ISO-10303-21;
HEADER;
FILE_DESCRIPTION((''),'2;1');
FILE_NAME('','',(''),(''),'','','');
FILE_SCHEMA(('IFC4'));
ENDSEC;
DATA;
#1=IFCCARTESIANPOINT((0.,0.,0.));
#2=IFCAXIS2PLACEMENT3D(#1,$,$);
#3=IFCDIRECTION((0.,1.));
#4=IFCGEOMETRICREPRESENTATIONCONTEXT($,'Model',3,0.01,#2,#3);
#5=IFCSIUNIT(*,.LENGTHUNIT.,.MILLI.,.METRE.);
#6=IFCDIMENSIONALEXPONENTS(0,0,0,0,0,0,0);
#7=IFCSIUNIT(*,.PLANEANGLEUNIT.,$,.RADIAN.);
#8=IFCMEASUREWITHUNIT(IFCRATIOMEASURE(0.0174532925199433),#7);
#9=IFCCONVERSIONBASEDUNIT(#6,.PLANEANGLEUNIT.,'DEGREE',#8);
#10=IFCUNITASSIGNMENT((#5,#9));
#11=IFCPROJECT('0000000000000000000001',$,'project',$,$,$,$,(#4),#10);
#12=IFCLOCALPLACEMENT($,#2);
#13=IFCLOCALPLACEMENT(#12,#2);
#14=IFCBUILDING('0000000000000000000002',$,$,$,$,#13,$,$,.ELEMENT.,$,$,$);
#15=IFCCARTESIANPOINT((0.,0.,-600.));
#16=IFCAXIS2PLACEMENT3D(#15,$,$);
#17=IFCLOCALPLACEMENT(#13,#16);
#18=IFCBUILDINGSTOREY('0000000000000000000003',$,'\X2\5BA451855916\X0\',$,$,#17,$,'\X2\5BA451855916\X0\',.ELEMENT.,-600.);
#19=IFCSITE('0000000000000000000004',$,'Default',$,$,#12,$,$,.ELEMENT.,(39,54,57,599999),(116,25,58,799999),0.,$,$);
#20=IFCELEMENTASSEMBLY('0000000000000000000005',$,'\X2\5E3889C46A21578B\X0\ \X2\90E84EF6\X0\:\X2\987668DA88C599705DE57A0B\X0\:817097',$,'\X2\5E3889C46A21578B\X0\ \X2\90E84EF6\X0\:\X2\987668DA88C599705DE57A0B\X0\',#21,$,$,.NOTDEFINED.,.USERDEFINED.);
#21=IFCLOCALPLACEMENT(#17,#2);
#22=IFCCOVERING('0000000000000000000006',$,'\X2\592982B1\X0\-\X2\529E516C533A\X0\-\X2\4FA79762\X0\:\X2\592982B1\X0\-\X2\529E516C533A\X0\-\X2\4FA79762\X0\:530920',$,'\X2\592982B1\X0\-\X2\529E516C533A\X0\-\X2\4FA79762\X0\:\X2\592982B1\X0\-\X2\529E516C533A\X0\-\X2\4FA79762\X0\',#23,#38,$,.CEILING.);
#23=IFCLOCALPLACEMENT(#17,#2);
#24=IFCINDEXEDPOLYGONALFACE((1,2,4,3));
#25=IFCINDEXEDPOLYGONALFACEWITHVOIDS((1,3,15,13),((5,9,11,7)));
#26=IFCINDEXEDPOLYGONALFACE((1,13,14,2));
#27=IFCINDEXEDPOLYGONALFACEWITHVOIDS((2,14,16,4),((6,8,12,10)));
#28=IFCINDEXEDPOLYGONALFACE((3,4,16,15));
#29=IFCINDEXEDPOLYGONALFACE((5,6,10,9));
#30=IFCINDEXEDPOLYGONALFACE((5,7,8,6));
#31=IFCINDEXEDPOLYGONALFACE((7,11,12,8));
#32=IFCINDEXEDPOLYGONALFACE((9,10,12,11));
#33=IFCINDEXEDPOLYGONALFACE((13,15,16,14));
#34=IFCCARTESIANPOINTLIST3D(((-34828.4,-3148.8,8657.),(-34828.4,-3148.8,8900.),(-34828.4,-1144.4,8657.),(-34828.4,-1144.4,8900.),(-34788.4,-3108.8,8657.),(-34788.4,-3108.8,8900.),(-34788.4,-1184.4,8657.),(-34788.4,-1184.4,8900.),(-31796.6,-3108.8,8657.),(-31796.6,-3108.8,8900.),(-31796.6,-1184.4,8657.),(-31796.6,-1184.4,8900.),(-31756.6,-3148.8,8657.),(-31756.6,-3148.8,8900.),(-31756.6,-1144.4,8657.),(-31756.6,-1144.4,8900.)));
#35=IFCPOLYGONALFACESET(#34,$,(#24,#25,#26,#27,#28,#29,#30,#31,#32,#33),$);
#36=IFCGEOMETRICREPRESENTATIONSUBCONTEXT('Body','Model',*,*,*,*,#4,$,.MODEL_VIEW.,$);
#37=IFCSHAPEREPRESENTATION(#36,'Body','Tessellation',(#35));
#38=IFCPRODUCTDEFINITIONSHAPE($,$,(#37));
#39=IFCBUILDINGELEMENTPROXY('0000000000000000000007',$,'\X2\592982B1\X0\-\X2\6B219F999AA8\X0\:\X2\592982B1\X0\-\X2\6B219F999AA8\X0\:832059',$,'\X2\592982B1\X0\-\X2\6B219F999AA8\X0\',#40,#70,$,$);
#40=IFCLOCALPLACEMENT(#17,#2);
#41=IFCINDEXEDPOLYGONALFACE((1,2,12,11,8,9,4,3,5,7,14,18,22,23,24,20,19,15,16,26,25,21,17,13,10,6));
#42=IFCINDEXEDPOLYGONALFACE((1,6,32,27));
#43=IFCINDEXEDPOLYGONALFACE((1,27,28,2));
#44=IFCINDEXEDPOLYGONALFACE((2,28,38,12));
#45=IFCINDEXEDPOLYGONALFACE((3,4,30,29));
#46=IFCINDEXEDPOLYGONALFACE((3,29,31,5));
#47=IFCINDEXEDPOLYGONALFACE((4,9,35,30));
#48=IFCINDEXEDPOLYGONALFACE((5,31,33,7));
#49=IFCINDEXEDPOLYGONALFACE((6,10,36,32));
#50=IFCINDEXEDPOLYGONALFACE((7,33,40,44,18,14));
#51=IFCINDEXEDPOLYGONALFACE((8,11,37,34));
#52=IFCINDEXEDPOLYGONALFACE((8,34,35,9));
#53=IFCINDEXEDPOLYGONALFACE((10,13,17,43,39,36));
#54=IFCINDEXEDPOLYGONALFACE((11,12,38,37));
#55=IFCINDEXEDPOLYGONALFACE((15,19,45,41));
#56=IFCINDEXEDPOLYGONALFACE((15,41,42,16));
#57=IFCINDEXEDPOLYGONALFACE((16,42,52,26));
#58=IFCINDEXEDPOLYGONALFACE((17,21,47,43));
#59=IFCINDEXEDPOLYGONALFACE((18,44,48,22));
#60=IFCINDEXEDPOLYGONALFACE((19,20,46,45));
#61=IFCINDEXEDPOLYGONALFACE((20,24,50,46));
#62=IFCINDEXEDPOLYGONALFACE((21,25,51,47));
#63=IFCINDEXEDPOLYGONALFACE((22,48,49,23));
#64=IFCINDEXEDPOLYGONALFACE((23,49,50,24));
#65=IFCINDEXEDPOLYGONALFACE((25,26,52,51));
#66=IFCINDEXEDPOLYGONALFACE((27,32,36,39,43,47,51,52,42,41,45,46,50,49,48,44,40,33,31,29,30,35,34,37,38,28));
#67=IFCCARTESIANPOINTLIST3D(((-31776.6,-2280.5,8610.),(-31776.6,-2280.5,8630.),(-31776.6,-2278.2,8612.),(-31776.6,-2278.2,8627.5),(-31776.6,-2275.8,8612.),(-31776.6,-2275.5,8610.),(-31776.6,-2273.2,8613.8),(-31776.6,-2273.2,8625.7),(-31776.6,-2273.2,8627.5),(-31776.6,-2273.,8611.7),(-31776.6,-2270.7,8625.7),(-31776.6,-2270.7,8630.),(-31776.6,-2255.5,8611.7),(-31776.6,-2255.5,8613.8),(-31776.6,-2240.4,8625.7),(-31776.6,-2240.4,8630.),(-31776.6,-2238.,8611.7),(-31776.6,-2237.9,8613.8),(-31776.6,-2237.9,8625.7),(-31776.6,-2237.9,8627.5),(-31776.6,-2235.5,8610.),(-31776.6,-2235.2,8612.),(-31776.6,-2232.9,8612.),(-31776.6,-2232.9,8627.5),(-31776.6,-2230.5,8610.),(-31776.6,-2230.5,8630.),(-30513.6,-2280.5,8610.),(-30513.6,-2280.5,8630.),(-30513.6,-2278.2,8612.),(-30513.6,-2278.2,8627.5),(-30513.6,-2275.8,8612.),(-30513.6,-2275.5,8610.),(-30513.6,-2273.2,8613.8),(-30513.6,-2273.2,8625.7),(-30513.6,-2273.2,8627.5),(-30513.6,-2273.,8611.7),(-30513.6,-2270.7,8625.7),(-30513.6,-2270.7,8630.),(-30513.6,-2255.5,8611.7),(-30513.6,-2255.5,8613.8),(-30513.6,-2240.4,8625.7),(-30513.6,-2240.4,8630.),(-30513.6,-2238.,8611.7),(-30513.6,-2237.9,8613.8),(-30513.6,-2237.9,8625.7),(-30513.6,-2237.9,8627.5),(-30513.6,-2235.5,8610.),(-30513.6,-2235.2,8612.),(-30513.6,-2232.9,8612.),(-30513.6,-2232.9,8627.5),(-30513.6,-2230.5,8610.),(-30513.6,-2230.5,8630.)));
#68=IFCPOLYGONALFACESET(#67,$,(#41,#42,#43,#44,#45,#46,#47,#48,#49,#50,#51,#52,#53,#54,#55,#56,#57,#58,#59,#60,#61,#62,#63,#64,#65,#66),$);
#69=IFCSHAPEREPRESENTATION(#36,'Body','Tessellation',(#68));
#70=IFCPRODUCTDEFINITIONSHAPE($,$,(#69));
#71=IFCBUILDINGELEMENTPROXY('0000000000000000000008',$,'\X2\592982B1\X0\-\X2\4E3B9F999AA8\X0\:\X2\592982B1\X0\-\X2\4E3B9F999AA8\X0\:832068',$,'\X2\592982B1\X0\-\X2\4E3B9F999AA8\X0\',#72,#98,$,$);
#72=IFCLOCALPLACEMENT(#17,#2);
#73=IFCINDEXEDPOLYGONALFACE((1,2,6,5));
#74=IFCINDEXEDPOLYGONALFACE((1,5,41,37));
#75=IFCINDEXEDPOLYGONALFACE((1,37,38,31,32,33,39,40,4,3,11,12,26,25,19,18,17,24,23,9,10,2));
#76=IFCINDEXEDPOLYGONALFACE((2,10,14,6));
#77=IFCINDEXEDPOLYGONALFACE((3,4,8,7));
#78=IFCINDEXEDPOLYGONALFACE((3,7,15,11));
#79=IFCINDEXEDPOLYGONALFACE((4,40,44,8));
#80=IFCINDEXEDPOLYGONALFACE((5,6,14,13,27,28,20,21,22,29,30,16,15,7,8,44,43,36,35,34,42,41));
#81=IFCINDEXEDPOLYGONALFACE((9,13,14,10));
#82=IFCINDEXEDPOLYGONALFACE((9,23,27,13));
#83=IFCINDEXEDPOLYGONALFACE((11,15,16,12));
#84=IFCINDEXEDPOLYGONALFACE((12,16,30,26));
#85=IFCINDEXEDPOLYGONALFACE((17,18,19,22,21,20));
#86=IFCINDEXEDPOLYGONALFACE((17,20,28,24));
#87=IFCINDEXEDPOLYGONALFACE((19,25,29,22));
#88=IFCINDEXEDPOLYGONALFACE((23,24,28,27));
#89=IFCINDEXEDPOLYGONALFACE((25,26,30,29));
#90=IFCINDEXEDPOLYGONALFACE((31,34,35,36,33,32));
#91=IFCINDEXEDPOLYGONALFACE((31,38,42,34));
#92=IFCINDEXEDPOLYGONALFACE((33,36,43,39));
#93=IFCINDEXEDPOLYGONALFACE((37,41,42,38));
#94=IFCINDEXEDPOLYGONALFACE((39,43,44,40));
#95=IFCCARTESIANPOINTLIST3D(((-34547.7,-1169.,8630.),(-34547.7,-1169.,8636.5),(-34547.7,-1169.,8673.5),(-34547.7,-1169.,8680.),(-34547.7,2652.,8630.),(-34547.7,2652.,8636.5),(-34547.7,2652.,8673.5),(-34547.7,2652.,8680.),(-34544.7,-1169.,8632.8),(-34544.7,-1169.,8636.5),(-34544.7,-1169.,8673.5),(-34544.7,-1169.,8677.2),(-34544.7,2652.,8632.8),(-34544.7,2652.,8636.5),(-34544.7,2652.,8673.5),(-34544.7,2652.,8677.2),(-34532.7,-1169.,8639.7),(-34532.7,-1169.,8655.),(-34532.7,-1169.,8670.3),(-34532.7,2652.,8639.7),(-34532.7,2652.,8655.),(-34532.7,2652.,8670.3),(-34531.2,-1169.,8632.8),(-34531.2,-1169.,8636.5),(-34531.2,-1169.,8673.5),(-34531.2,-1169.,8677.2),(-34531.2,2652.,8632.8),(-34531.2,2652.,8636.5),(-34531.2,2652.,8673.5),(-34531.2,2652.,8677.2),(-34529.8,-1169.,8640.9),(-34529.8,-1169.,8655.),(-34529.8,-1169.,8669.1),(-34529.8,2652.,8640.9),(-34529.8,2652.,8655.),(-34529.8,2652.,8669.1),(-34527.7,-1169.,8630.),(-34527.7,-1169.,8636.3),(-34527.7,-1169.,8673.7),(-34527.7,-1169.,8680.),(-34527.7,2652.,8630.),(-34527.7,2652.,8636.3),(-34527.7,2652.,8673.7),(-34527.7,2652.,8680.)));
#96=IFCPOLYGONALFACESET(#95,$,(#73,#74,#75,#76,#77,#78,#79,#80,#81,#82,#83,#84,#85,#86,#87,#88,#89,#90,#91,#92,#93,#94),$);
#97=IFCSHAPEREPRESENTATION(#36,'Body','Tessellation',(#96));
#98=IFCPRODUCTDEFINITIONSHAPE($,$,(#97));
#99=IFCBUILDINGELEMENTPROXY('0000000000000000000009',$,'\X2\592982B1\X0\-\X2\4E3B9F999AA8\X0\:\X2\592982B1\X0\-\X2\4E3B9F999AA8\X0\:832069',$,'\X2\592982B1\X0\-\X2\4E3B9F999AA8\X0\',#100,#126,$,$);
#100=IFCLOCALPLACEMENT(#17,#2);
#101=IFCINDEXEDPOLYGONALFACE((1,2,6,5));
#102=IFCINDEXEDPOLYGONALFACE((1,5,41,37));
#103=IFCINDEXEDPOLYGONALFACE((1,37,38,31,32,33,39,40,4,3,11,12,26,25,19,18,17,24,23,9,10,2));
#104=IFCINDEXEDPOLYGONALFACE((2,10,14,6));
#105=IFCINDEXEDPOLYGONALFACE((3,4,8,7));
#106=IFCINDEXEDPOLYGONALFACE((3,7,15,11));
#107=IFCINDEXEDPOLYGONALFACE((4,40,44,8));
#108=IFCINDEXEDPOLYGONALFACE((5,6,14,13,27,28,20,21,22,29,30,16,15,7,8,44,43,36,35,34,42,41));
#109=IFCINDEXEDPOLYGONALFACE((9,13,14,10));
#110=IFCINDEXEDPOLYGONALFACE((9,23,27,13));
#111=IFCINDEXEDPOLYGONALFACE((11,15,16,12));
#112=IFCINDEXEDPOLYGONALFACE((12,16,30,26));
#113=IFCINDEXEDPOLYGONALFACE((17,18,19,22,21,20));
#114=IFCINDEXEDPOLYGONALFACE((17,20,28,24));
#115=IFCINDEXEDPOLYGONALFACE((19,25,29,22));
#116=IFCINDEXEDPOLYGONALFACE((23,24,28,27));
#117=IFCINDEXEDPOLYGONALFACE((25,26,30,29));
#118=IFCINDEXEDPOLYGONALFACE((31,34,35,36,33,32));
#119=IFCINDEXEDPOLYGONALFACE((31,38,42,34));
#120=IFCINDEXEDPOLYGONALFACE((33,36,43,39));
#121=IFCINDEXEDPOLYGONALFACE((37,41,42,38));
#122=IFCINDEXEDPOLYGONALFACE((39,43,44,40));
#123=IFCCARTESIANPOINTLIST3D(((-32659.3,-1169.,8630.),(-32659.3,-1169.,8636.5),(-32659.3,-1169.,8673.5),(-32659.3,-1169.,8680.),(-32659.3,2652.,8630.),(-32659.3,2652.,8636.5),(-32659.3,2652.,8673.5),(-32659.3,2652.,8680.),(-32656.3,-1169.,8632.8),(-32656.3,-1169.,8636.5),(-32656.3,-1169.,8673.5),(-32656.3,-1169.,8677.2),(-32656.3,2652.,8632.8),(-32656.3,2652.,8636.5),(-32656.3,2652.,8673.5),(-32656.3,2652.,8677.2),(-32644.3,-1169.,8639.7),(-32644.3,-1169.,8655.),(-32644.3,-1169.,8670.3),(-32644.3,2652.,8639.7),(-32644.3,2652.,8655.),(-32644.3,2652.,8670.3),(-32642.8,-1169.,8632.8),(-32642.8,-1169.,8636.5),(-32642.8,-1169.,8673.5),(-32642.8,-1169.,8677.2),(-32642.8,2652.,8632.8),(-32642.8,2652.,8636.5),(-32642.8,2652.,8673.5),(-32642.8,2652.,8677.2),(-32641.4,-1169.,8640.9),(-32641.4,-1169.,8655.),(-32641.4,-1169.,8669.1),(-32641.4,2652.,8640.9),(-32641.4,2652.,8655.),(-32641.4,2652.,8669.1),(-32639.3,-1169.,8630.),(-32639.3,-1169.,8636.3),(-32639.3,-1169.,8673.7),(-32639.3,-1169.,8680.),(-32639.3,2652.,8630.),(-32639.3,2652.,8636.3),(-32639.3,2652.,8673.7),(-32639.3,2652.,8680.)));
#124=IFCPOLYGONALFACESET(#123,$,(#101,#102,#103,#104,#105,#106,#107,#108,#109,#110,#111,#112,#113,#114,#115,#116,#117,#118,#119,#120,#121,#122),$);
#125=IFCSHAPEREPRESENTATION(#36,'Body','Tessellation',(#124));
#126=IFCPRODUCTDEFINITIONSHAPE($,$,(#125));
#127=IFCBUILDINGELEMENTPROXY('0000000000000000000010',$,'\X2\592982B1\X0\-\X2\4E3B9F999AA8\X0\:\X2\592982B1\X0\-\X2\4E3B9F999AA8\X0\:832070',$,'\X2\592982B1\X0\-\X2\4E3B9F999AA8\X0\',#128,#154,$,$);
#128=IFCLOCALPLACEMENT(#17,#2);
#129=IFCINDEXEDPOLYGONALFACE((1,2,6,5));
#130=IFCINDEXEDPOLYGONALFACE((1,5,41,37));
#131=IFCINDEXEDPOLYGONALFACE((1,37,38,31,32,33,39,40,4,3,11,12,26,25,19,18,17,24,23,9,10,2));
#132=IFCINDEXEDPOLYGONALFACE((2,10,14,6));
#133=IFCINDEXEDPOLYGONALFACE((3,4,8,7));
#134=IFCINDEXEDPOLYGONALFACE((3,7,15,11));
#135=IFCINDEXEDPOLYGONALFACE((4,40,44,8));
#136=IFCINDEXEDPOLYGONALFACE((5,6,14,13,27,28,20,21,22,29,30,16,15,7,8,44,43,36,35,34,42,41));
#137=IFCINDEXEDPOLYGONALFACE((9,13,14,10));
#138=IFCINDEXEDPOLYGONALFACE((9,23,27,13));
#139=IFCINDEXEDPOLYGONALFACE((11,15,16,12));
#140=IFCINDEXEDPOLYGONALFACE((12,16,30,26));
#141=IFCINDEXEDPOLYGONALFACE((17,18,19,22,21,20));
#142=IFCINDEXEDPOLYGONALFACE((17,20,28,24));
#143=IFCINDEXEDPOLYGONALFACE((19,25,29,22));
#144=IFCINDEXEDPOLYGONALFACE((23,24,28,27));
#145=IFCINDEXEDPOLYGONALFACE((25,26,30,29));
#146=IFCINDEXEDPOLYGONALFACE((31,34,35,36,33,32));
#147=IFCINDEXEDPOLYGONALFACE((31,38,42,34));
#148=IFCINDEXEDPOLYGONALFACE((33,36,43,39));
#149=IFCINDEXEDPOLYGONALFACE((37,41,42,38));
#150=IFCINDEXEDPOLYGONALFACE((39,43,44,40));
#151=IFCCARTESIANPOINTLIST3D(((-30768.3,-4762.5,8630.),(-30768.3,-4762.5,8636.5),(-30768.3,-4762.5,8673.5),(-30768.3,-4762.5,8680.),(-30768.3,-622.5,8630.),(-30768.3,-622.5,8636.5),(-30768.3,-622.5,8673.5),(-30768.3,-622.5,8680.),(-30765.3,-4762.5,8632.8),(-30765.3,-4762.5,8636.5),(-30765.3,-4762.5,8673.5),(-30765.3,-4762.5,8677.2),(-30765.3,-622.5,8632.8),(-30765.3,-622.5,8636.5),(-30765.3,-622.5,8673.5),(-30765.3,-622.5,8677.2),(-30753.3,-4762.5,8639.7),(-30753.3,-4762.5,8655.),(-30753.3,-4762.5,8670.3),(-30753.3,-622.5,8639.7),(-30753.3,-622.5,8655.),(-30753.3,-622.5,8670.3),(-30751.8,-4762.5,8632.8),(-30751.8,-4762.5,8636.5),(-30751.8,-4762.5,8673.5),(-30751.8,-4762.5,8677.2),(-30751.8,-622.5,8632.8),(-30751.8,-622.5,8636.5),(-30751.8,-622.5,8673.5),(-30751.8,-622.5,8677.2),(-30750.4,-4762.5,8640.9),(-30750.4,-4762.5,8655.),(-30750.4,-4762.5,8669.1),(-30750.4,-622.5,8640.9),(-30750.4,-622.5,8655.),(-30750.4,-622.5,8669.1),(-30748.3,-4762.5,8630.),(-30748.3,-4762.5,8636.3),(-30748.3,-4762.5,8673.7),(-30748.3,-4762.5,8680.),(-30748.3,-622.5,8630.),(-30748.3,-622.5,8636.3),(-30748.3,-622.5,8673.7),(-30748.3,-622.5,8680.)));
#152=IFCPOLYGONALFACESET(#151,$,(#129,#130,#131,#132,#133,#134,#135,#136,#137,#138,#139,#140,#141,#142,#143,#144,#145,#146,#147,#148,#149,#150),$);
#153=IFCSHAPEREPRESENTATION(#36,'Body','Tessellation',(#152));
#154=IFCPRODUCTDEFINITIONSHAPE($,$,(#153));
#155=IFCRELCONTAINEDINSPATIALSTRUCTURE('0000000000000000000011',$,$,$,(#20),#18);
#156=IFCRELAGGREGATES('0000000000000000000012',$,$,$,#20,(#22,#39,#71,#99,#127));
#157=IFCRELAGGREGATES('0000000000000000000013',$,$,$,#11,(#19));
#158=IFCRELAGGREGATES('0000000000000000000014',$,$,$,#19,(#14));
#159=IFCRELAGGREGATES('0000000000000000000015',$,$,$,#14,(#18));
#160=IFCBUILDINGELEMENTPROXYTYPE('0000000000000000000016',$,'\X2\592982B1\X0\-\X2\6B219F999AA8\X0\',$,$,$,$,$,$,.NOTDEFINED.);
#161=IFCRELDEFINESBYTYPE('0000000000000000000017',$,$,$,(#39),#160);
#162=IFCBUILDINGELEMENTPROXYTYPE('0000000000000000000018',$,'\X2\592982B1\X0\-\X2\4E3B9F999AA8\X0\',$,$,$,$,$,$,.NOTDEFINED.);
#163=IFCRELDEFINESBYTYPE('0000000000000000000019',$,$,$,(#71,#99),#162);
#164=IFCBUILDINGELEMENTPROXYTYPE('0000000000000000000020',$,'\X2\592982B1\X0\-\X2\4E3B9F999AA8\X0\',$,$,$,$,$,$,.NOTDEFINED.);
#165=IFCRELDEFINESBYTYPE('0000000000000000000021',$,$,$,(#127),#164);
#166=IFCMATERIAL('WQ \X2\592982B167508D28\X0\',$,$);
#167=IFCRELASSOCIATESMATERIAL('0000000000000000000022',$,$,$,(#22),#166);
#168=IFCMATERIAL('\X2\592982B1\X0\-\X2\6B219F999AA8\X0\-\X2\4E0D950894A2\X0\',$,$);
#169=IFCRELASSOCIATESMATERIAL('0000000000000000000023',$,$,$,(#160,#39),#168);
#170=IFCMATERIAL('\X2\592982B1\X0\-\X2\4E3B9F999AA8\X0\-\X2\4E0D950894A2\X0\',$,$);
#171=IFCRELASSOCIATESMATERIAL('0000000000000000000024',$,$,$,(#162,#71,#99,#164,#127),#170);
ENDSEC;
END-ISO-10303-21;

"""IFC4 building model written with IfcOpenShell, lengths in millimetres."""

from ifc_helpers import new_model, entity, si_unit, converted_unit, direction, frame, origin, place, context, subcontext, project, spatial, polyline, outline, extrude, source, transform, mapped, material, type_object, type_shapes, element, aggregate, save


model = new_model("IFC4")

# Units and contexts
model_context = context("Model", 3, precision=0.01, world=origin(), true_north=direction((0.0, 1.0)))
body_context = subcontext(model_context, "Body", "Model", "MODEL_VIEW")
ifc_project = project(units=[si_unit("LENGTHUNIT", "METRE", prefix="MILLI"), converted_unit("PLANEANGLEUNIT", "DEGREE", entity("IfcRatioMeasure", 0.0174532925199433), si_unit("PLANEANGLEUNIT", "RADIAN"), dimensions=[0, 0, 0, 0, 0, 0, 0])], contexts=[model_context])

# Site, building, storey
site_placement = place(None, origin())
site = spatial("IfcSite", under=ifc_project, at=site_placement, Name="Default", CompositionType="ELEMENT", RefLatitude=(39, 54, 57, 599999), RefLongitude=(116, 25, 58, 799999), RefElevation=0.0)
building_placement = place(site_placement, origin())
building = spatial("IfcBuilding", under=site, at=building_placement, CompositionType="ELEMENT")
storey_placement = place(building_placement, frame((0.0, 0.0, -600.0)))
storey = spatial("IfcBuildingStorey", under=building, at=storey_placement, Name="室内外", LongName="室内外", CompositionType="ELEMENT", Elevation=-600.0)

# Element assembly, covering, building element proxies
assembly_placement = place(storey_placement, origin())
assembly = element("IfcElementAssembly", 1, at=assembly_placement, inside=storey, Name="常规模型 部件:顶棚装饰工程:817097", ObjectType="常规模型 部件:顶棚装饰工程", AssemblyPlace="NOTDEFINED", PredefinedType="USERDEFINED")
ifc_material_1 = material(Name="WQ 天花材质")
covering_1_placement = place(assembly_placement, frame((-34828.4, -3148.8, 8657.0)))
covering_1 = element("IfcCovering", 2, at=covering_1_placement, material=ifc_material_1, Name="天花-办公区-侧面:天花-办公区-侧面:530920", ObjectType="天花-办公区-侧面:天花-办公区-侧面", PredefinedType="CEILING", context=body_context, shape_type="SweptSolid", body=[
    extrude(outline(polyline([(-1535.9, -1002.2), (1535.9, -1002.2), (1535.9, 1002.2), (-1535.9, 1002.2), (-1535.9, -1002.2)]), holes=[polyline([(-1495.9, -962.2), (-1495.9, 962.2), (1495.9, 962.2), (1495.9, -962.2), (-1495.9, -962.2)])]), frame((1535.9, 1002.2, 0.0), z_axis=(0.0, 0.0, 1.0), x_axis=(-1.0, 0.0, 0.0)), (0.0, 0.0, 1.0), 243.0),
])
ifc_material_2 = material(Name="天花-次龙骨-不锈钢")
building_element_proxy_type_1 = type_object("IfcBuildingElementProxyType", Name="天花-次龙骨", PredefinedType="NOTDEFINED", material=ifc_material_2)
shared_shape_1 = source(origin(), body_context, "Body", "SweptSolid", [
    extrude(outline(polyline([(-25.0, -9.1), (-20.0, -9.1), (-17.5, -7.4), (0.0, -7.4), (17.5, -7.4), (20.0, -9.1), (25.0, -9.1), (25.0, 10.9), (15.1, 10.9), (15.1, 6.6), (17.6, 6.6), (17.6, 8.4), (22.6, 8.4), (22.6, -7.1), (20.3, -7.1), (17.6, -5.3), (0.0, -5.3), (-17.6, -5.3), (-20.3, -7.1), (-22.6, -7.1), (-22.6, 8.4), (-17.6, 8.4), (-17.6, 6.6), (-15.1, 6.6), (-15.1, 10.9), (-25.0, 10.9), (-25.0, -9.1)])), frame((0.0, 0.0, -0.9), z_axis=(1.0, 0.0, 0.0), x_axis=(0.0, 1.0, 0.0)), (0.0, 0.0, 1.0), 1263.0),
])
type_shapes(building_element_proxy_type_1, [shared_shape_1])
proxy_1_placement = place(assembly_placement, frame((-31776.6, -2255.5, 8620.0)))
proxy_1 = element("IfcBuildingElementProxy", 3, at=proxy_1_placement, type_object=building_element_proxy_type_1, material=ifc_material_2, Name="天花-次龙骨:天花-次龙骨:832059", ObjectType="天花-次龙骨", context=body_context, shape_type="MappedRepresentation", body=[
    mapped(shared_shape_1, transform((0.0, 0.0, 0.0), scale=1.0)),
])
ifc_material_3 = material(Name="天花-主龙骨-不锈钢")
building_element_proxy_type_2 = type_object("IfcBuildingElementProxyType", Name="天花-主龙骨", PredefinedType="NOTDEFINED", material=ifc_material_3)
shared_shape_2 = source(origin(), body_context, "Body", "SweptSolid", [
    extrude(outline(polyline([(-25.0, -11.7), (-18.5, -11.7), (-18.5, -8.7), (-22.2, -8.7), (-22.2, 4.8), (-18.5, 4.8), (-15.3, 3.3), (0.0, 3.3), (15.3, 3.3), (18.5, 4.8), (22.2, 4.8), (22.2, -8.7), (18.5, -8.7), (18.5, -11.7), (25.0, -11.7), (25.0, 8.3), (18.7, 8.3), (14.1, 6.2), (0.0, 6.2), (-14.1, 6.2), (-18.7, 8.3), (-25.0, 8.3), (-25.0, -11.7)])), frame((0.0, 1.7, 0.0), z_axis=(1.0, 0.0, 0.0), x_axis=(0.0, 0.0, -1.0)), (0.0, 0.0, 1.0), 3821.0),
])
type_shapes(building_element_proxy_type_2, [shared_shape_2])
proxy_2_placement = place(assembly_placement, frame((-34537.7, 2652.0, 8655.0), z_axis=(0.0, 0.0, 1.0), x_axis=(0.0, -1.0, 0.0)))
proxy_2 = element("IfcBuildingElementProxy", 4, at=proxy_2_placement, type_object=building_element_proxy_type_2, material=ifc_material_3, Name="天花-主龙骨:天花-主龙骨:832068", ObjectType="天花-主龙骨", context=body_context, shape_type="MappedRepresentation", body=[
    mapped(shared_shape_2, transform((0.0, 0.0, 0.0), scale=1.0)),
])
proxy_3_placement = place(assembly_placement, frame((-32649.3, 2652.0, 8655.0), z_axis=(0.0, 0.0, 1.0), x_axis=(0.0, -1.0, 0.0)))
proxy_3 = element("IfcBuildingElementProxy", 5, at=proxy_3_placement, type_object=building_element_proxy_type_2, material=ifc_material_3, Name="天花-主龙骨:天花-主龙骨:832069", ObjectType="天花-主龙骨", context=body_context, shape_type="MappedRepresentation", body=[
    mapped(shared_shape_2, transform((0.0, 0.0, 0.0), scale=1.0)),
])
building_element_proxy_type_3 = type_object("IfcBuildingElementProxyType", Name="天花-主龙骨", PredefinedType="NOTDEFINED", material=ifc_material_3)
shared_shape_3 = source(origin(), body_context, "Body", "SweptSolid", [
    extrude(outline(polyline([(-25.0, -11.7), (-18.5, -11.7), (-18.5, -8.7), (-22.2, -8.7), (-22.2, 4.8), (-18.5, 4.8), (-15.3, 3.3), (0.0, 3.3), (15.3, 3.3), (18.5, 4.8), (22.2, 4.8), (22.2, -8.7), (18.5, -8.7), (18.5, -11.7), (25.0, -11.7), (25.0, 8.3), (18.7, 8.3), (14.1, 6.2), (0.0, 6.2), (-14.1, 6.2), (-18.7, 8.3), (-25.0, 8.3), (-25.0, -11.7)])), frame((0.0, 1.7, 0.0), z_axis=(1.0, 0.0, 0.0), x_axis=(0.0, 0.0, -1.0)), (0.0, 0.0, 1.0), 4140.0),
])
type_shapes(building_element_proxy_type_3, [shared_shape_3])
proxy_4_placement = place(assembly_placement, frame((-30758.3, -622.5, 8655.0), z_axis=(0.0, 0.0, 1.0), x_axis=(0.0, -1.0, 0.0)))
proxy_4 = element("IfcBuildingElementProxy", 6, at=proxy_4_placement, type_object=building_element_proxy_type_3, material=ifc_material_3, Name="天花-主龙骨:天花-主龙骨:832070", ObjectType="天花-主龙骨", context=body_context, shape_type="MappedRepresentation", body=[
    mapped(shared_shape_3, transform((0.0, 0.0, 0.0), scale=1.0)),
])
aggregate(assembly, [covering_1, proxy_1, proxy_2, proxy_3, proxy_4])

save(model, "model.ifc")
